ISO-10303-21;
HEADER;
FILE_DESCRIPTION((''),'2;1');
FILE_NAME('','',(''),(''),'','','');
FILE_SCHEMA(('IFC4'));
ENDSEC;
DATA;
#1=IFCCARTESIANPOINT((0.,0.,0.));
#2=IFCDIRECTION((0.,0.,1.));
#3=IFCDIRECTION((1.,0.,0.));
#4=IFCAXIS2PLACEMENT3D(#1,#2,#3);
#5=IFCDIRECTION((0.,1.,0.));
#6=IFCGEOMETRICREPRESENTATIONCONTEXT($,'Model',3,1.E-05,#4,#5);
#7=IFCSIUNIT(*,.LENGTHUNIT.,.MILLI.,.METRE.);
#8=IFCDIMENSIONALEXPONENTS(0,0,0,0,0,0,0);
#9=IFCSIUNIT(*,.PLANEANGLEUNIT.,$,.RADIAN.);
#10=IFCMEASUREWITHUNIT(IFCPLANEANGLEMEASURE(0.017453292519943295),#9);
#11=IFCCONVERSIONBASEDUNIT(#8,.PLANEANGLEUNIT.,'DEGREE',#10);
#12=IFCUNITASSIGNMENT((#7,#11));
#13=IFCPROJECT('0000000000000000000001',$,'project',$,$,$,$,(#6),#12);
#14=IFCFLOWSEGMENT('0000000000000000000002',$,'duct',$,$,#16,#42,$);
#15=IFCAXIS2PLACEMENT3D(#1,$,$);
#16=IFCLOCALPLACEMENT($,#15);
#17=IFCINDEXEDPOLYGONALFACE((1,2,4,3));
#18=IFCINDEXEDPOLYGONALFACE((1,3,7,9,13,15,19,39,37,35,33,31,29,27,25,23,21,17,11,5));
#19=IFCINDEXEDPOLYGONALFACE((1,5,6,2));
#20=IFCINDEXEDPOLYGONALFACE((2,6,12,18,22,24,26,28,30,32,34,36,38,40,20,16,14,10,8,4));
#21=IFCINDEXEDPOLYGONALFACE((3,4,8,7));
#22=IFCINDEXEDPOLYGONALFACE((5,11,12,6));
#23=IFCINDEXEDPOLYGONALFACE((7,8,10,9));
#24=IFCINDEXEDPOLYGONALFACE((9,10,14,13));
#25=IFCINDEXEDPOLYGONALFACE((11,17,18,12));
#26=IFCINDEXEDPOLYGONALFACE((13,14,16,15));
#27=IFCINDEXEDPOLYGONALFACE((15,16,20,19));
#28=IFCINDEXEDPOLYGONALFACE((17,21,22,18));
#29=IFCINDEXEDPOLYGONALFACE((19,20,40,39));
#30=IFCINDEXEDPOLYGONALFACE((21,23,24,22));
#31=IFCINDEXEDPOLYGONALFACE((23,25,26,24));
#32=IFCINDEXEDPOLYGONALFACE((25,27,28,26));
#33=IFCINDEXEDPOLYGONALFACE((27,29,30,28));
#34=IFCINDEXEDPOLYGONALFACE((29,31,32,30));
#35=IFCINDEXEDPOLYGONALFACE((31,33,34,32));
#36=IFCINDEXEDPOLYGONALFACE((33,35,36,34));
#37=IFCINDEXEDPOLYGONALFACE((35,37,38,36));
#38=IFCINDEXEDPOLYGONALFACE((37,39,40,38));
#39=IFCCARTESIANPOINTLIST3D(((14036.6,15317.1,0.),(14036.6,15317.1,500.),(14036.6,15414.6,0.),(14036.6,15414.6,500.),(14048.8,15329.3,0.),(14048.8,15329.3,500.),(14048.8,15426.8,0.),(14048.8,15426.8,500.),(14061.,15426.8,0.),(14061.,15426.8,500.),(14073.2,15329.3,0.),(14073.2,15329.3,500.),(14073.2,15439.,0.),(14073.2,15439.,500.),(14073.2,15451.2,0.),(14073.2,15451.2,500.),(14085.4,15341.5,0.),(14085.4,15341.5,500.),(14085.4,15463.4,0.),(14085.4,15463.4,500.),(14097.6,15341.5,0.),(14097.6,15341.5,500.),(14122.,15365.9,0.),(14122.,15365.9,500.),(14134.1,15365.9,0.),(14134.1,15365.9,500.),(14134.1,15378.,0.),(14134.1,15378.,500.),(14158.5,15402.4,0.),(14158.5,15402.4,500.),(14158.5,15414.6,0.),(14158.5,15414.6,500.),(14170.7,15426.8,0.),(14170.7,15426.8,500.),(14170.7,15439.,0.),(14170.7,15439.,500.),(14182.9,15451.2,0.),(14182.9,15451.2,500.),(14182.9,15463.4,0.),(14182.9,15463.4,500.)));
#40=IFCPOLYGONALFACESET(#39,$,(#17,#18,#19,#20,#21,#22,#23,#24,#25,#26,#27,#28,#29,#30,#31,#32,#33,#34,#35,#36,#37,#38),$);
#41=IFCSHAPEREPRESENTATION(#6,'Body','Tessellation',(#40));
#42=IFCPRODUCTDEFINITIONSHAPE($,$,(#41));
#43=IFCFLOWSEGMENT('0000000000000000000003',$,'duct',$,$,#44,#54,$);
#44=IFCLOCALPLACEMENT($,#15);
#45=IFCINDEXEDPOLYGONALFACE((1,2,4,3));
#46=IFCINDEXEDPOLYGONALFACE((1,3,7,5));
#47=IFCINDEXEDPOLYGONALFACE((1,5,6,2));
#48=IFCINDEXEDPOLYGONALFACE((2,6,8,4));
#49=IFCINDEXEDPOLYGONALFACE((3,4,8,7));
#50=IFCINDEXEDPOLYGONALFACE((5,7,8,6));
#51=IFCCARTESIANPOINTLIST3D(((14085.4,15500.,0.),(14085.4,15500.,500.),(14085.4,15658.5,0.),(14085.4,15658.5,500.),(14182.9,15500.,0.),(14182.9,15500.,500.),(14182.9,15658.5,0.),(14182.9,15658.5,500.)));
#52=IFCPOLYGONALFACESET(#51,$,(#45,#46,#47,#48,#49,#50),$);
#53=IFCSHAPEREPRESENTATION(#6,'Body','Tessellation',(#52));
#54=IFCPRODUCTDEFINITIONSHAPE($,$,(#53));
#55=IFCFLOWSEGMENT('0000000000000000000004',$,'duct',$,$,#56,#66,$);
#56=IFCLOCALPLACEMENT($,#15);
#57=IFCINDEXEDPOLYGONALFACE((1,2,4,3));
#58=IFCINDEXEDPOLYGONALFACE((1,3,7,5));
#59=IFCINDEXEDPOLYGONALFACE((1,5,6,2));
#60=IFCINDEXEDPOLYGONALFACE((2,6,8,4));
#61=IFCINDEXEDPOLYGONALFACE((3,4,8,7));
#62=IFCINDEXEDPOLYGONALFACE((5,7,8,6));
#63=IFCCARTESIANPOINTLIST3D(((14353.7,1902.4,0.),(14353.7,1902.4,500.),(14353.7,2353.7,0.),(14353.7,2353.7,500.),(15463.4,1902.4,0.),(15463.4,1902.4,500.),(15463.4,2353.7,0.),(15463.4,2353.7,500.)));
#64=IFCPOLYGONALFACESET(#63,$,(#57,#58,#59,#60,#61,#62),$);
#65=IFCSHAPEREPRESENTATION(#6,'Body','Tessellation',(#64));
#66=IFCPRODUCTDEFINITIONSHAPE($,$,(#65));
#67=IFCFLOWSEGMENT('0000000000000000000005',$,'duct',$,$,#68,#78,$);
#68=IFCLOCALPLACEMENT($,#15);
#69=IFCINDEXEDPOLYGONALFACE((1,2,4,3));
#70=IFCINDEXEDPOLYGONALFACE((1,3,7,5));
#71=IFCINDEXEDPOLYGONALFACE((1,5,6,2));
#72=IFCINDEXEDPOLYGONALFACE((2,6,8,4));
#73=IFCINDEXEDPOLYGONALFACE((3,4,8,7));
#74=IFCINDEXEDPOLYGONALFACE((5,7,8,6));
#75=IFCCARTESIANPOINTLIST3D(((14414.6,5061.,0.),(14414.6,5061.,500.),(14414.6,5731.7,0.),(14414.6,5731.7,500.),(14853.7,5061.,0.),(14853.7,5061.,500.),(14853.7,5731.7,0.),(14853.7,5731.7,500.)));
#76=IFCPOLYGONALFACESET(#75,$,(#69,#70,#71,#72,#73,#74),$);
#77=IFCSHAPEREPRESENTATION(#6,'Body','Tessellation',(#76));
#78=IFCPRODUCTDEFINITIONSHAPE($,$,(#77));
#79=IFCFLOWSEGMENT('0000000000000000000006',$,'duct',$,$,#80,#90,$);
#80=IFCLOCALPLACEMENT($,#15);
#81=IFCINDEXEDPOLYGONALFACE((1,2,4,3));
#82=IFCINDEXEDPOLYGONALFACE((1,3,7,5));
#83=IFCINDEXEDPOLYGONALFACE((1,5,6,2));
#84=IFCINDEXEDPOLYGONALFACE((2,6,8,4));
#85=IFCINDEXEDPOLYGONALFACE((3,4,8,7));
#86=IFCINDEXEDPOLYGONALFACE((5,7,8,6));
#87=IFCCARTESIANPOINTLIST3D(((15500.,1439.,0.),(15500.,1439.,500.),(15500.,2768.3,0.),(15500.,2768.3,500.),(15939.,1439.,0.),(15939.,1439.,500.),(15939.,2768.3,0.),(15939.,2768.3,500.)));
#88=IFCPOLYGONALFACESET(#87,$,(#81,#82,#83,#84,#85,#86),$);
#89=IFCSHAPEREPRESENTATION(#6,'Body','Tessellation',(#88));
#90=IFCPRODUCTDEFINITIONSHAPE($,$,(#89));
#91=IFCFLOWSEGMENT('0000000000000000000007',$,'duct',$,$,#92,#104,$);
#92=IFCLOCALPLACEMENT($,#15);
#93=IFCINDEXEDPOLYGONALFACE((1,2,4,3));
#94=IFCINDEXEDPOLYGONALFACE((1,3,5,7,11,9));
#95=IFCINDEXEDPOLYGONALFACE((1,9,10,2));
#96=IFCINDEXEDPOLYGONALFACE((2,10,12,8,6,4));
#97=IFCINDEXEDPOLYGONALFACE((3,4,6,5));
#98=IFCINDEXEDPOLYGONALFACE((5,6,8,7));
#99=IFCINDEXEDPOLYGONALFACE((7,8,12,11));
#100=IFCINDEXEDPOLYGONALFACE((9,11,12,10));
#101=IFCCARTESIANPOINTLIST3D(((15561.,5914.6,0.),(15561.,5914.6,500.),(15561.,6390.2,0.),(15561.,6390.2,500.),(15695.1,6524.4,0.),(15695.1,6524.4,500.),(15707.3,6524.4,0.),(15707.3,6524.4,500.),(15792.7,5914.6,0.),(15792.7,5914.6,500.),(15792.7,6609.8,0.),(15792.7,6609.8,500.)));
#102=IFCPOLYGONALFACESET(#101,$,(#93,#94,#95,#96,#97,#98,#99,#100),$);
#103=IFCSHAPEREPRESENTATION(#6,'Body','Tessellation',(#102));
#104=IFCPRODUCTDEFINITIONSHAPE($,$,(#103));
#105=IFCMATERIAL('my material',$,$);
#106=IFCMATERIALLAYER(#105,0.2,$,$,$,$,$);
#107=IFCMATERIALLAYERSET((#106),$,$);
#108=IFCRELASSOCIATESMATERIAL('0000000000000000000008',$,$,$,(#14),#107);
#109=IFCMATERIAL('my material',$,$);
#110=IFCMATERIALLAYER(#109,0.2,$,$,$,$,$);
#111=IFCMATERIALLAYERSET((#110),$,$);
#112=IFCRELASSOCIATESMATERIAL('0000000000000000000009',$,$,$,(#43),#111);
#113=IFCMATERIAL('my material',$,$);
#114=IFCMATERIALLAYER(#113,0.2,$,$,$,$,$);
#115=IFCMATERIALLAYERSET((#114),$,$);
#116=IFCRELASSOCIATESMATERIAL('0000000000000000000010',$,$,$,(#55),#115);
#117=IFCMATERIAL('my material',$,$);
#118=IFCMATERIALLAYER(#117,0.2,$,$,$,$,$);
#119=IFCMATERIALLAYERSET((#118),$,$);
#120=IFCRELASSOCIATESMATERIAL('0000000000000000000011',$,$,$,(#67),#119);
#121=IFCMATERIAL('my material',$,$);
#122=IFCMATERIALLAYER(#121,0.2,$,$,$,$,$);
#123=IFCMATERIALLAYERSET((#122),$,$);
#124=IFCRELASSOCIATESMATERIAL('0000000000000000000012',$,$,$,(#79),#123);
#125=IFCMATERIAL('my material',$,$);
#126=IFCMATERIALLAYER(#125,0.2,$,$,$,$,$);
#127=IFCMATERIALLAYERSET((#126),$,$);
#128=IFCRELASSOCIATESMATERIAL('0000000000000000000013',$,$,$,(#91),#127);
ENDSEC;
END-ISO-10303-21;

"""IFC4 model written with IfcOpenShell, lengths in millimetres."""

from ifc_helpers import new_model, entity, si_unit, converted_unit, direction, origin_with_axes, place, context, project, polyline, outline, extrude, material, layer, layer_set, layer_usage, element, save


model = new_model("IFC4")

# Units and contexts
model_context = context("Model", 3, precision=1e-05, world=origin_with_axes(), true_north=direction((0.0, 1.0, 0.0)))
ifc_project = project(units=[si_unit("LENGTHUNIT", "METRE", prefix="MILLI"), converted_unit("PLANEANGLEUNIT", "DEGREE", entity("IfcPlaneAngleMeasure", 0.017453292519943295), si_unit("PLANEANGLEUNIT", "RADIAN"), dimensions=[0, 0, 0, 0, 0, 0, 0])], contexts=[model_context])

# Flow segments
ifc_material_1 = material(Name="my material")
ifc_layer_1 = layer(ifc_material_1, 0.2)
ifc_layer_set_1 = layer_set([ifc_layer_1])
ifc_layer_usage_1 = layer_usage(ifc_layer_set_1, "AXIS2", "POSITIVE", -0.1)
flow_segment_1_placement = place(None, origin_with_axes())
element("IfcFlowSegment", 1, at=flow_segment_1_placement, material=ifc_layer_usage_1, Name="duct", context=model_context, shape_type="SweptSolid", body=[
    extrude(outline(polyline([(14036.6, 15317.1), (14048.8, 15329.3), (14073.2, 15329.3), (14085.4, 15341.5), (14097.6, 15341.5), (14122.0, 15365.9), (14134.1, 15365.9), (14134.1, 15378.0), (14158.5, 15402.4), (14158.5, 15414.6), (14170.7, 15426.8), (14170.7, 15439.0), (14182.9, 15451.2), (14182.9, 15463.4), (14085.4, 15463.4), (14073.2, 15451.2), (14073.2, 15439.0), (14061.0, 15426.8), (14048.8, 15426.8), (14036.6, 15414.6), (14036.6, 15317.1)])), origin_with_axes(), (0.0, 0.0, 1.0), 500.0),
])
ifc_material_2 = material(Name="my material")
ifc_layer_2 = layer(ifc_material_2, 0.2)
ifc_layer_set_2 = layer_set([ifc_layer_2])
ifc_layer_usage_2 = layer_usage(ifc_layer_set_2, "AXIS2", "POSITIVE", -0.1)
flow_segment_2_placement = place(None, origin_with_axes())
element("IfcFlowSegment", 2, at=flow_segment_2_placement, material=ifc_layer_usage_2, Name="duct", context=model_context, shape_type="SweptSolid", body=[
    extrude(outline(polyline([(14085.4, 15500.0), (14182.9, 15500.0), (14182.9, 15658.5), (14085.4, 15658.5), (14085.4, 15500.0)])), origin_with_axes(), (0.0, 0.0, 1.0), 500.0),
])
ifc_material_3 = material(Name="my material")
ifc_layer_3 = layer(ifc_material_3, 0.2)
ifc_layer_set_3 = layer_set([ifc_layer_3])
ifc_layer_usage_3 = layer_usage(ifc_layer_set_3, "AXIS2", "POSITIVE", -0.1)
flow_segment_3_placement = place(None, origin_with_axes())
element("IfcFlowSegment", 3, at=flow_segment_3_placement, material=ifc_layer_usage_3, Name="duct", context=model_context, shape_type="SweptSolid", body=[
    extrude(outline(polyline([(14353.7, 1902.4), (15463.4, 1902.4), (15463.4, 2353.7), (14353.7, 2353.7), (14353.7, 1902.4)])), origin_with_axes(), (0.0, 0.0, 1.0), 500.0),
])
ifc_material_4 = material(Name="my material")
ifc_layer_4 = layer(ifc_material_4, 0.2)
ifc_layer_set_4 = layer_set([ifc_layer_4])
ifc_layer_usage_4 = layer_usage(ifc_layer_set_4, "AXIS2", "POSITIVE", -0.1)
flow_segment_4_placement = place(None, origin_with_axes())
element("IfcFlowSegment", 4, at=flow_segment_4_placement, material=ifc_layer_usage_4, Name="duct", context=model_context, shape_type="SweptSolid", body=[
    extrude(outline(polyline([(14414.6, 5061.0), (14853.7, 5061.0), (14853.7, 5731.7), (14414.6, 5731.7), (14414.6, 5061.0)])), origin_with_axes(), (0.0, 0.0, 1.0), 500.0),
])
ifc_material_5 = material(Name="my material")
ifc_layer_5 = layer(ifc_material_5, 0.2)
ifc_layer_set_5 = layer_set([ifc_layer_5])
ifc_layer_usage_5 = layer_usage(ifc_layer_set_5, "AXIS2", "POSITIVE", -0.1)
flow_segment_5_placement = place(None, origin_with_axes())
element("IfcFlowSegment", 5, at=flow_segment_5_placement, material=ifc_layer_usage_5, Name="duct", context=model_context, shape_type="SweptSolid", body=[
    extrude(outline(polyline([(15500.0, 1439.0), (15939.0, 1439.0), (15939.0, 2768.3), (15500.0, 2768.3), (15500.0, 1439.0)])), origin_with_axes(), (0.0, 0.0, 1.0), 500.0),
])
ifc_material_6 = material(Name="my material")
ifc_layer_6 = layer(ifc_material_6, 0.2)
ifc_layer_set_6 = layer_set([ifc_layer_6])
ifc_layer_usage_6 = layer_usage(ifc_layer_set_6, "AXIS2", "POSITIVE", -0.1)
flow_segment_6_placement = place(None, origin_with_axes())
element("IfcFlowSegment", 6, at=flow_segment_6_placement, material=ifc_layer_usage_6, Name="duct", context=model_context, shape_type="SweptSolid", body=[
    extrude(outline(polyline([(15561.0, 5914.6), (15792.7, 5914.6), (15792.7, 6609.8), (15707.3, 6524.4), (15695.1, 6524.4), (15561.0, 6390.2), (15561.0, 5914.6)])), origin_with_axes(), (0.0, 0.0, 1.0), 500.0),
])

save(model, "model.ifc")
